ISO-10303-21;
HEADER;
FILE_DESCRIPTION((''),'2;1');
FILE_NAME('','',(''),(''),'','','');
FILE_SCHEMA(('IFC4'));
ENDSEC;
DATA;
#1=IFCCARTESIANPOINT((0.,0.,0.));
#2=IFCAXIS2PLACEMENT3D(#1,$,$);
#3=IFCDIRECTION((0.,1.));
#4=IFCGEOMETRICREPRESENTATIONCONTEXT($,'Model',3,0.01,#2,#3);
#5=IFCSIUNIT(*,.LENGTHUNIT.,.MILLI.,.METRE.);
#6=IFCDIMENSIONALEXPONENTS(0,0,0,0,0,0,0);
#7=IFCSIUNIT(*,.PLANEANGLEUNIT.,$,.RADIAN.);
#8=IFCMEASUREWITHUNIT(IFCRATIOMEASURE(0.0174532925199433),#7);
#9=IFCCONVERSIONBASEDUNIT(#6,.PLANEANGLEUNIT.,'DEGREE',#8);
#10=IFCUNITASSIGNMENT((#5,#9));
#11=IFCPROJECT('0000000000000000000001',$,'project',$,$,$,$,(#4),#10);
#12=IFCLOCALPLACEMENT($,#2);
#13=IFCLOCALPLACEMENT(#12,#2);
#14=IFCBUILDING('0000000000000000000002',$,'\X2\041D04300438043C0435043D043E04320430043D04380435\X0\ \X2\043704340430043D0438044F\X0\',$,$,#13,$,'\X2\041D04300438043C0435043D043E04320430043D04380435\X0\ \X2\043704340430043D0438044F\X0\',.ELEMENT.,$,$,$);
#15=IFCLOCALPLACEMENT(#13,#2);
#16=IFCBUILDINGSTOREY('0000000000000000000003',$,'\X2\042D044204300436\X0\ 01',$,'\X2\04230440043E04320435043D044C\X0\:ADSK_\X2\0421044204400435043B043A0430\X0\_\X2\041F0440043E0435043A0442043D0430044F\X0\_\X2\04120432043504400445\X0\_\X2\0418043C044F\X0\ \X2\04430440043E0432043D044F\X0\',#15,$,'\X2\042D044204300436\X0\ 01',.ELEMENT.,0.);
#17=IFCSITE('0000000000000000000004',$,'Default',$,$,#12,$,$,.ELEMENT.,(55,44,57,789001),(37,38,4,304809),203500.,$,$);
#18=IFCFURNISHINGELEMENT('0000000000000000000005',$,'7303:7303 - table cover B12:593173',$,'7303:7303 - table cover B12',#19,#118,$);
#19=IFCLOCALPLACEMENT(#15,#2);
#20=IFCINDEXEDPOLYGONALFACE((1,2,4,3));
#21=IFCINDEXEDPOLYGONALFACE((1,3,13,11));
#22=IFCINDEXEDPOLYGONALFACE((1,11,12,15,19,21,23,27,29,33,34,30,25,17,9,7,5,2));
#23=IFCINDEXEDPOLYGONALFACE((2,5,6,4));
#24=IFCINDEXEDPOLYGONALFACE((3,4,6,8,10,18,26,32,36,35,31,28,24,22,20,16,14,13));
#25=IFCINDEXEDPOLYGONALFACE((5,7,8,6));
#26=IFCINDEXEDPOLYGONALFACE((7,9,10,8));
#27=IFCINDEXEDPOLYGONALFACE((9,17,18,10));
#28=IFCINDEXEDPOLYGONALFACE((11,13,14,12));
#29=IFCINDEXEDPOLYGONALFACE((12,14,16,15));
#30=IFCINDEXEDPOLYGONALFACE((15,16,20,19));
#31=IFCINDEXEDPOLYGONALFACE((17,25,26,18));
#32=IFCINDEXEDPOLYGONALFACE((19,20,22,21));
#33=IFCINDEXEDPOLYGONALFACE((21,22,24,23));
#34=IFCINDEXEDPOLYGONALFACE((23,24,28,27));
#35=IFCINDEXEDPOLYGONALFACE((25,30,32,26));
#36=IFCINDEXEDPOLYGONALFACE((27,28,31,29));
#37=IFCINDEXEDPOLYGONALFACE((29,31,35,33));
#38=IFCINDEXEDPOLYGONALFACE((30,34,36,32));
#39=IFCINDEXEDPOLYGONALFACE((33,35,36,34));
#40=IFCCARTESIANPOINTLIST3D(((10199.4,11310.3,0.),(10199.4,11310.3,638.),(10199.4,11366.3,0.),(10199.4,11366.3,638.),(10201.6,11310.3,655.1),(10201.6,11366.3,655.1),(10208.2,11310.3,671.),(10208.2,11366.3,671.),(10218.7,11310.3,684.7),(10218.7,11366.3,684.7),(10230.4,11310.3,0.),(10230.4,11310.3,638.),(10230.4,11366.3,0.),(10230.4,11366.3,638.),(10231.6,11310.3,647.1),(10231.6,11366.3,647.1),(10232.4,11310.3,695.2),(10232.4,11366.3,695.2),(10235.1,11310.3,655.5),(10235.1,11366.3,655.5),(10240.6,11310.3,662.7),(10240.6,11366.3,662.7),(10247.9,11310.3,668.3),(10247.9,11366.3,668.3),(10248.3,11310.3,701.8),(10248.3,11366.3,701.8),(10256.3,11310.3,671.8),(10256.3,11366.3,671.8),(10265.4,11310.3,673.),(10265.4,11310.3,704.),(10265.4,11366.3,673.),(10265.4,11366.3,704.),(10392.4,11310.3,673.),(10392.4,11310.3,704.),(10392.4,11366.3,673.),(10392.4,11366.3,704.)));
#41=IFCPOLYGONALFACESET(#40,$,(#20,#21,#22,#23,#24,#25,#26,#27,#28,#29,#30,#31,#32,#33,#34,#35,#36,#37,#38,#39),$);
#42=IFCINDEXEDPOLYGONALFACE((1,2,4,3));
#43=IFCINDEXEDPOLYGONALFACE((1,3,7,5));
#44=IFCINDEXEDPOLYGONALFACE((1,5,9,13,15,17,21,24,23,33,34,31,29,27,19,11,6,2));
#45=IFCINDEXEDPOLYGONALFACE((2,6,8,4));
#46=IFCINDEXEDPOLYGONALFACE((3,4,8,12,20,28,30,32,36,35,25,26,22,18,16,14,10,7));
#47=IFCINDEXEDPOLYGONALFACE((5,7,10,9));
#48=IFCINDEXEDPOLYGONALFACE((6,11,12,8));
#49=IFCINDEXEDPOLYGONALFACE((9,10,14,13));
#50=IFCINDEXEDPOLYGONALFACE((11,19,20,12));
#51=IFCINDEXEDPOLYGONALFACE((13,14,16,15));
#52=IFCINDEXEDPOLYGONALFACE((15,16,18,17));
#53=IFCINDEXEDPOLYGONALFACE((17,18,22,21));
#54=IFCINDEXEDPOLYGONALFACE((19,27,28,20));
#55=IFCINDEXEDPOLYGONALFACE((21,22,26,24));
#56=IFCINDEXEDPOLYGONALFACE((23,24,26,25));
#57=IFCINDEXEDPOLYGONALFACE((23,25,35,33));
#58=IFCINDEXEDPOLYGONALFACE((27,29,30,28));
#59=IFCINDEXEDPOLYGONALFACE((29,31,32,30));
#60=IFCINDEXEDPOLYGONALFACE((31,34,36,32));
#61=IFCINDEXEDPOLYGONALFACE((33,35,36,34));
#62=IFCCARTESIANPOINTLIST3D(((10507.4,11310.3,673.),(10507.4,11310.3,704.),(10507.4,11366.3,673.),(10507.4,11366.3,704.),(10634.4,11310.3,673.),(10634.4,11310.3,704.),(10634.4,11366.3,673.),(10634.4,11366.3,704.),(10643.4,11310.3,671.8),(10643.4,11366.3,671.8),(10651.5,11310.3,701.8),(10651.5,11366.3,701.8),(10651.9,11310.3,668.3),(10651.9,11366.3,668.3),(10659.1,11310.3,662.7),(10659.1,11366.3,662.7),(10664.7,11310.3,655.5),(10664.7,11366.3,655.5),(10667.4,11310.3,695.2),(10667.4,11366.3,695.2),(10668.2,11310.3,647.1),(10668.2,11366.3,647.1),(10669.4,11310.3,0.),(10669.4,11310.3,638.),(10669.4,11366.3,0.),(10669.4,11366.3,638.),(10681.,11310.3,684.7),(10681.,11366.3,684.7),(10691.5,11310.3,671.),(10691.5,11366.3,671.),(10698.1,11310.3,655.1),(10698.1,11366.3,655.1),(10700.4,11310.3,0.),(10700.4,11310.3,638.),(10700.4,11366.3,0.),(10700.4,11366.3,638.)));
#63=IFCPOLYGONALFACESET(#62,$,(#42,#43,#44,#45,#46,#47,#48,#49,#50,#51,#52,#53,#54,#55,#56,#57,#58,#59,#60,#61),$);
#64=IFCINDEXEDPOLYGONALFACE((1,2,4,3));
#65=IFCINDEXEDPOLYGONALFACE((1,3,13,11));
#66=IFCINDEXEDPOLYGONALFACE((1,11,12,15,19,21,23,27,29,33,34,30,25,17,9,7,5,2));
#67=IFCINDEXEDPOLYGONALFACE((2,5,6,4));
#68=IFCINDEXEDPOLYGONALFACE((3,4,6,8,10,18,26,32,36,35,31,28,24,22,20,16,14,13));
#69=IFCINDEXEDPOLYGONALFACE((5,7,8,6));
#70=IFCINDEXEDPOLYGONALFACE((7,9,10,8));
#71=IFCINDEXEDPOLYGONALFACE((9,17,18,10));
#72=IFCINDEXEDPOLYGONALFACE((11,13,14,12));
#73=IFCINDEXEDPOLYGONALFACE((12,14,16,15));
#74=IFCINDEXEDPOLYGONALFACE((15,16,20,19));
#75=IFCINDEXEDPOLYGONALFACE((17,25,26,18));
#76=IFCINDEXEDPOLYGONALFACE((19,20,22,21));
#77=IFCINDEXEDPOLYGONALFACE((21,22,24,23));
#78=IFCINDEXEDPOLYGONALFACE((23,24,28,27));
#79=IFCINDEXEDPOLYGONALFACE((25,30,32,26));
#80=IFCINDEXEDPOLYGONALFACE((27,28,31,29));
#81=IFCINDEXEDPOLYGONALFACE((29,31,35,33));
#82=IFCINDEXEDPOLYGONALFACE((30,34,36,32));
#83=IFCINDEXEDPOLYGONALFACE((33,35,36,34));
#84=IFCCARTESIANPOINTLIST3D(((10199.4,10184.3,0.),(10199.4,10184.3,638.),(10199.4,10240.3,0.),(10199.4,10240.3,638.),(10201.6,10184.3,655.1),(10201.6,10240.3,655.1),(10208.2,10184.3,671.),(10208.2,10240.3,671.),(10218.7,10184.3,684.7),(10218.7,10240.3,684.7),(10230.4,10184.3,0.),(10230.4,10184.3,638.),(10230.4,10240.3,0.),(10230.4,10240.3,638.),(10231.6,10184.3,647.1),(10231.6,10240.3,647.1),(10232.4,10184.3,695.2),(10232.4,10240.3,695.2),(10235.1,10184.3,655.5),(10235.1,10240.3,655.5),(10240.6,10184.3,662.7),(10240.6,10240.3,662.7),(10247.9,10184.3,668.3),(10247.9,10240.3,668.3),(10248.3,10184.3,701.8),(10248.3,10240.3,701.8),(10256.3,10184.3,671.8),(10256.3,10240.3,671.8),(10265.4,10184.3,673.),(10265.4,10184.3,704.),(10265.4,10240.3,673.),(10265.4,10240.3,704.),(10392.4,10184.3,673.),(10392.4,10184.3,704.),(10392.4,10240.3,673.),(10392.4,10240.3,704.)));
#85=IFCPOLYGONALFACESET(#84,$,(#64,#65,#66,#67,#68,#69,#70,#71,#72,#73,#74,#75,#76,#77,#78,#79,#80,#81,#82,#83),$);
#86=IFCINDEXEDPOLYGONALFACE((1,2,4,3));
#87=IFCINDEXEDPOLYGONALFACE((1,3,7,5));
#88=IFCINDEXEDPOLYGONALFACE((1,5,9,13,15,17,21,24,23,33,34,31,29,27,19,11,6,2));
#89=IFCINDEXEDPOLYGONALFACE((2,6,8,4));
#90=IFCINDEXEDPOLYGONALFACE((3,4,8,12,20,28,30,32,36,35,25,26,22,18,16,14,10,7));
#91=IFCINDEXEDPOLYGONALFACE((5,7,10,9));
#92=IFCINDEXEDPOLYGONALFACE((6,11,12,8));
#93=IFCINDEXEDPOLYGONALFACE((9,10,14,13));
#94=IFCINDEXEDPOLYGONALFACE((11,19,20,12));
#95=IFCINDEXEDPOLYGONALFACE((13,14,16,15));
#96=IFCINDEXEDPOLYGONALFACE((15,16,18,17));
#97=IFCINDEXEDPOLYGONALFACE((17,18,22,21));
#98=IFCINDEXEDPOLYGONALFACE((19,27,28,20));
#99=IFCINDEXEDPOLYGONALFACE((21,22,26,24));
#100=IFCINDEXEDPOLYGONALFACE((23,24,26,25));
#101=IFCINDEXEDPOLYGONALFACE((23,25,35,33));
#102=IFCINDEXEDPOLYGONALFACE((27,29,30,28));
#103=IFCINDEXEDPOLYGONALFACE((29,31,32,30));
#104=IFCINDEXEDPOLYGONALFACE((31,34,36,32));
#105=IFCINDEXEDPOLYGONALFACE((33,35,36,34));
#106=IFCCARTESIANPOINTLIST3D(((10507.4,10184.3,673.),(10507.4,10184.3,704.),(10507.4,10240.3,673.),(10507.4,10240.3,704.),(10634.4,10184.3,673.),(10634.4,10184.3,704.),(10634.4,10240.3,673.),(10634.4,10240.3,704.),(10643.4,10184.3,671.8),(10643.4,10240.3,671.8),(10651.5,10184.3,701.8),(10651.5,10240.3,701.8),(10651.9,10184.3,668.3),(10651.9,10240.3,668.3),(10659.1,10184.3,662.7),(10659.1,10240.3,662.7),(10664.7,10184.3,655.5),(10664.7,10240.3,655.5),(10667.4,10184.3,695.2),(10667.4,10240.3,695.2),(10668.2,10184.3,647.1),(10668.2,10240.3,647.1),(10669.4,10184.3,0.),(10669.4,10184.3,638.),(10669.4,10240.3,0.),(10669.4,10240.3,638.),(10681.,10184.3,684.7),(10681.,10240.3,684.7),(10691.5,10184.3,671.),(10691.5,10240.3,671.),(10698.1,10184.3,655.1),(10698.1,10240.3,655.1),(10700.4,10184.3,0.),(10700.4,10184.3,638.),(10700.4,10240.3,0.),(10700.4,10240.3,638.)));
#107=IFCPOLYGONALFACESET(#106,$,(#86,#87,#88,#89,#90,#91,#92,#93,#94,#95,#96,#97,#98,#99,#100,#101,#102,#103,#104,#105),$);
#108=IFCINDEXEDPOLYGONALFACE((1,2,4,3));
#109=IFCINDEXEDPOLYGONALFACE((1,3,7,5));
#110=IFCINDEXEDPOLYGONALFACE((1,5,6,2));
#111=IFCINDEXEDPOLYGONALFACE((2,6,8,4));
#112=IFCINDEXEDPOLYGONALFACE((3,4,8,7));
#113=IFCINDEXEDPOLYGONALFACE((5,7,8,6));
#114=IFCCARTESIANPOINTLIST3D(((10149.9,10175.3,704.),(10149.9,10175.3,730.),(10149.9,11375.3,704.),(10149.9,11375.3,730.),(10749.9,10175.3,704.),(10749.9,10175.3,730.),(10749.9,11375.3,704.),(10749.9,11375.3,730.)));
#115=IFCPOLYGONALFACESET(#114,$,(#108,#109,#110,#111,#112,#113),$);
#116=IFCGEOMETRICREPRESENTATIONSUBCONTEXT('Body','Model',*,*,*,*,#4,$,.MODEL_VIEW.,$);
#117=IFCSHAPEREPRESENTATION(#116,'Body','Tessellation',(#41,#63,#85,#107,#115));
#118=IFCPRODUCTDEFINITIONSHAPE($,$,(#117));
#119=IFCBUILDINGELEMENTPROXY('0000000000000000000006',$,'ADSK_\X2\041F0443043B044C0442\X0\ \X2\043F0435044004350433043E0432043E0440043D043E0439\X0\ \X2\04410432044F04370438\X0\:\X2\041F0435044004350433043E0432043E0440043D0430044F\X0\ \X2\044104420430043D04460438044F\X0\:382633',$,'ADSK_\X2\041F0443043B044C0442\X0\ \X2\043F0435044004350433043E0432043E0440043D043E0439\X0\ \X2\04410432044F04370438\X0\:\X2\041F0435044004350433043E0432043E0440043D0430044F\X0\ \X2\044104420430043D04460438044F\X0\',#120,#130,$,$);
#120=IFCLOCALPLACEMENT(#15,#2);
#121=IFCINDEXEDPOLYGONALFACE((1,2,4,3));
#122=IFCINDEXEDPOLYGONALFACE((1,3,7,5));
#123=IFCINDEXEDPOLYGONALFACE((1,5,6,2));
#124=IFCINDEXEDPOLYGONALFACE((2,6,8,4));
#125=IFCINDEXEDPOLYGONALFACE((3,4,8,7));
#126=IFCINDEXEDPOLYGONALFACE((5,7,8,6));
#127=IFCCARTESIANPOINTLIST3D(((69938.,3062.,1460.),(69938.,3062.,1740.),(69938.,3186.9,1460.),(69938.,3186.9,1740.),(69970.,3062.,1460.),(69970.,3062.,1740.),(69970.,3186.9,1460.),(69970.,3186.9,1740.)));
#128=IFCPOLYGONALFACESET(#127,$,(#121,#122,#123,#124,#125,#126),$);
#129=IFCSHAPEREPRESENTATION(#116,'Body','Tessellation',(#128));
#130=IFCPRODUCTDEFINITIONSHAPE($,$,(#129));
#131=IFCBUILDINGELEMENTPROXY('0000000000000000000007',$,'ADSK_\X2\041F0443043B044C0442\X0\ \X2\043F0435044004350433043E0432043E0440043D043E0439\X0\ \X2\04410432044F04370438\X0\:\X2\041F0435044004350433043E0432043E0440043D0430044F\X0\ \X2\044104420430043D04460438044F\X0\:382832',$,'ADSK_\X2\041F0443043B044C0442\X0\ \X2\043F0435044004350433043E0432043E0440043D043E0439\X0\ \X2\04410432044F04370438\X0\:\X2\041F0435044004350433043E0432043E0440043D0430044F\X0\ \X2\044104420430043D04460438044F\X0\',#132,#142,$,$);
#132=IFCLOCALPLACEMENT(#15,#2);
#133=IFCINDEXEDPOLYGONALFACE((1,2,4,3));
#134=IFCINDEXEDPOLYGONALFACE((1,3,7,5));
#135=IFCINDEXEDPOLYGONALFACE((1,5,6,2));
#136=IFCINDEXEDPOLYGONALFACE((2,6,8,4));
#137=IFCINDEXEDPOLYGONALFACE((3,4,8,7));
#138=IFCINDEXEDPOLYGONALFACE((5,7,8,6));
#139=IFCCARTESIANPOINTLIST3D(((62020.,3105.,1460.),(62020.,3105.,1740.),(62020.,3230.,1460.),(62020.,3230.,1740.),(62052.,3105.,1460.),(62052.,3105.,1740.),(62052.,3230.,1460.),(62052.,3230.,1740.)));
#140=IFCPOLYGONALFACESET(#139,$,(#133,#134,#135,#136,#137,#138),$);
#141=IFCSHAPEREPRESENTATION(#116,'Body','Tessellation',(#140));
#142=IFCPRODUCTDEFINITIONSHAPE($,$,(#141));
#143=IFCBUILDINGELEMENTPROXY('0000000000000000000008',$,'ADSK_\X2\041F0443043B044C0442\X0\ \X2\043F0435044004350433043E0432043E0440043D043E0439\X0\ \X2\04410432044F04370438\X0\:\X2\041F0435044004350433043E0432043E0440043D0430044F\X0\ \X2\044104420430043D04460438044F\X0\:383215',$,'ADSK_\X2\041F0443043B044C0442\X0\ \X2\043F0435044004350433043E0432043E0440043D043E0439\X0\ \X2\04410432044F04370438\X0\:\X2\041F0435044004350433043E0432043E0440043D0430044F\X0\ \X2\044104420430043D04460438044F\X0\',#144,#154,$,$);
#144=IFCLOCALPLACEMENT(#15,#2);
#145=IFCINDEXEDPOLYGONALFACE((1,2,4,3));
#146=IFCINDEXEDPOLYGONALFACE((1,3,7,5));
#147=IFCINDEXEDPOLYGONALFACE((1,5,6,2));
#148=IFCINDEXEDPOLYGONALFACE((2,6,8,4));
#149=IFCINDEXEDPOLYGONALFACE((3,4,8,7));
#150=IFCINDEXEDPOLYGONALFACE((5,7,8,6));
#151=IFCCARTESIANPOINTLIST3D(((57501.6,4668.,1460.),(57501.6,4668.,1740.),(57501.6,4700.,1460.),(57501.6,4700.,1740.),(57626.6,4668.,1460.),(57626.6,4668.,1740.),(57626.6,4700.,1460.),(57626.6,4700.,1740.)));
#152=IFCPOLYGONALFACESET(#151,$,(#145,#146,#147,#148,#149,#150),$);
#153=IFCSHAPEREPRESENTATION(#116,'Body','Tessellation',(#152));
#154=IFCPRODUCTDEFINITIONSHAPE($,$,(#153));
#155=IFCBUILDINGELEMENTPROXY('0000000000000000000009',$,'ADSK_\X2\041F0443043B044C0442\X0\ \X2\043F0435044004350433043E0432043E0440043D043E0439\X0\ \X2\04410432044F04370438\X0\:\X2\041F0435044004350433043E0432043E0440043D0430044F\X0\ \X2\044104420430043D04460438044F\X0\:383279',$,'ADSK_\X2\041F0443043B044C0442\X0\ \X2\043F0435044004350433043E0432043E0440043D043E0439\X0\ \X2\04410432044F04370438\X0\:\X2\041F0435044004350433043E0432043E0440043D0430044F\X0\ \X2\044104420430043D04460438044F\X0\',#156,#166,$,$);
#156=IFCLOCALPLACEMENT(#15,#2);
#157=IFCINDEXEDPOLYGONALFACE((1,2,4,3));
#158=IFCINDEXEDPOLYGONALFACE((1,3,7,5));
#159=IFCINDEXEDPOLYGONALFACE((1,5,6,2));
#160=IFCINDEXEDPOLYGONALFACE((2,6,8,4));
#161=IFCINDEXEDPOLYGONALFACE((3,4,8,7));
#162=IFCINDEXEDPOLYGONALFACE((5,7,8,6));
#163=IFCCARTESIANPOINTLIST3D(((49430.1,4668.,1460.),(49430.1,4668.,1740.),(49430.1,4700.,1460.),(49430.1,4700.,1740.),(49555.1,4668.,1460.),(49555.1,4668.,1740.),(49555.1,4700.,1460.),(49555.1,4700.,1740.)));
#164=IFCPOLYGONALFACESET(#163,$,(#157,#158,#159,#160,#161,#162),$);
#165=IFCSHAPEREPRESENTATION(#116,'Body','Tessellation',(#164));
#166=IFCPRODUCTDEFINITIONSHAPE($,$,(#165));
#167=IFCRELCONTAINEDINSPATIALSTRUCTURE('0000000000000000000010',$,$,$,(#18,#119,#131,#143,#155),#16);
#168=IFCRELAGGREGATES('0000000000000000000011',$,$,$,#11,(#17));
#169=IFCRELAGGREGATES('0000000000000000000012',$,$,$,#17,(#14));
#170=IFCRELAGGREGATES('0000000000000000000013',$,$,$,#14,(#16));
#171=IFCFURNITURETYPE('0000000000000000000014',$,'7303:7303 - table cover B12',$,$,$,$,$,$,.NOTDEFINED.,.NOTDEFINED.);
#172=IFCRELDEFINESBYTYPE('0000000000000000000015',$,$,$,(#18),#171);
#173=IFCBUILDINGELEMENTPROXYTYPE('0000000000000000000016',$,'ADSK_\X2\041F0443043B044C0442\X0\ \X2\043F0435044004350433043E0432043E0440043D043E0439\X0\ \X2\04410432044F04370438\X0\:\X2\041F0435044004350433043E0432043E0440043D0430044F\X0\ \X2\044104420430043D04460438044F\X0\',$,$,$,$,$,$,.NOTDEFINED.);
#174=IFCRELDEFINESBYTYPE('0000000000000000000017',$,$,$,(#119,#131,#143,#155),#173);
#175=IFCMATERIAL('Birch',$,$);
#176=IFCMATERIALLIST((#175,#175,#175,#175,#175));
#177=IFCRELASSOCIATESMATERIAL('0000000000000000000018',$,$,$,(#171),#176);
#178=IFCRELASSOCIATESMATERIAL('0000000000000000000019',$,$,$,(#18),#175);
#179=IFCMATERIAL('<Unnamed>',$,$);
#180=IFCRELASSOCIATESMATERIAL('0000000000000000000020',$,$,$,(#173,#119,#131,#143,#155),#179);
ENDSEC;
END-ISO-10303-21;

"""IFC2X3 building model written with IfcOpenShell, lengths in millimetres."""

from ifc_helpers import new_model, entity, si_unit, converted_unit, direction, frame, frame_2d, origin, origin_2d_with_axis, place, context, subcontext, project, spatial, polyline, circle_curve, parameter, trimmed, segment, composite_curve, rectangle, outline, extrude, source, transform, mapped, material, material_list, type_object, type_shapes, element, save


model = new_model("IFC2X3")

# Units and contexts
model_context = context("Model", 3, precision=0.01, world=origin(), true_north=direction((0.0, 1.0)))
body_context = subcontext(model_context, "Body", "Model", "MODEL_VIEW")
ifc_project = project(units=[si_unit("LENGTHUNIT", "METRE", prefix="MILLI"), converted_unit("PLANEANGLEUNIT", "DEGREE", entity("IfcRatioMeasure", 0.0174532925199433), si_unit("PLANEANGLEUNIT", "RADIAN"), dimensions=[0, 0, 0, 0, 0, 0, 0])], contexts=[model_context])

# Site, building, storey
site_placement = place(None, origin())
site = spatial("IfcSite", under=ifc_project, at=site_placement, Name="Default", CompositionType="ELEMENT", RefLatitude=(55, 44, 57, 789001), RefLongitude=(37, 38, 4, 304809), RefElevation=203500.0)
building_placement = place(site_placement, origin())
building = spatial("IfcBuilding", under=site, at=building_placement, Name="Наименование здания", LongName="Наименование здания", CompositionType="ELEMENT")
storey_placement = place(building_placement, origin())
storey = spatial("IfcBuildingStorey", under=building, at=storey_placement, Name="Этаж 01", ObjectType="Уровень:ADSK_Стрелка_Проектная_Вверх_Имя уровня", LongName="Этаж 01", CompositionType="ELEMENT", Elevation=0.0)

# Furnishing element
ifc_material_1 = material(Name="Birch")
ifc_material_list_1 = material_list([ifc_material_1, ifc_material_1, ifc_material_1, ifc_material_1, ifc_material_1])
furniture_type = type_object("IfcFurnitureType", Name="7303:7303 - table cover B12", material=ifc_material_list_1)
shared_shape_1 = source(origin(), body_context, "Body", "SweptSolid", [
    extrude(outline(composite_curve([segment(polyline([(-200.2, -120.5), (-169.2, -120.5)]), True, "CONTINUOUS"), segment(polyline([(-169.2, -120.5), (-169.2, 6.5)]), True, "CONTINUOUS"), segment(trimmed(circle_curve(frame_2d((-134.2, 6.5), x_axis=(0.0, -1.0)), 35.0), [parameter(180.0)], [parameter(270.0)], True, "PARAMETER"), False, "CONTINUOUS"), segment(polyline([(-134.2, 41.5), (503.8, 41.5)]), True, "CONTINUOUS"), segment(polyline([(503.8, 41.5), (503.8, 72.5)]), True, "CONTINUOUS"), segment(polyline([(503.8, 72.5), (-134.2, 72.5)]), True, "CONTINUOUS"), segment(trimmed(circle_curve(frame_2d((-134.2, 6.5), x_axis=(0.0, -1.0)), 66.0), [parameter(180.0)], [parameter(270.0)], True, "PARAMETER"), True, "CONTINUOUS"), segment(polyline([(-200.2, 6.5), (-200.2, -120.5)]), True, "CONTINUOUS")], self_intersect=False)), frame((535.0, 178.0, 503.8), z_axis=(1.0, 0.0, 0.0), x_axis=(0.0, 0.0, -1.0)), (0.0, 0.0, 1.0), 56.0),
    extrude(outline(composite_curve([segment(polyline([(-120.5, -200.2), (6.5, -200.2)]), True, "CONTINUOUS"), segment(trimmed(circle_curve(frame_2d((6.5, -134.2), x_axis=(-1.0, 0.0)), 66.0), [parameter(90.0)], [parameter(180.0)], True, "PARAMETER"), True, "CONTINUOUS"), segment(polyline([(72.5, -134.2), (72.5, 503.8)]), True, "CONTINUOUS"), segment(polyline([(72.5, 503.8), (41.5, 503.8)]), True, "CONTINUOUS"), segment(polyline([(41.5, 503.8), (41.5, -134.2)]), True, "CONTINUOUS"), segment(trimmed(circle_curve(frame_2d((6.5, -134.2), x_axis=(-1.0, 0.0)), 35.0), [parameter(90.0)], [parameter(180.0)], True, "PARAMETER"), False, "CONTINUOUS"), segment(polyline([(6.5, -169.2), (-120.5, -169.2)]), True, "CONTINUOUS"), segment(polyline([(-120.5, -169.2), (-120.5, -200.2)]), True, "CONTINUOUS")], self_intersect=False)), frame((535.0, -178.0, 503.8), z_axis=(1.0, 0.0, 0.0), x_axis=(0.0, -1.0, 0.0)), (0.0, 0.0, 1.0), 56.0),
    extrude(outline(composite_curve([segment(polyline([(-200.2, -120.5), (-169.2, -120.5)]), True, "CONTINUOUS"), segment(polyline([(-169.2, -120.5), (-169.2, 6.5)]), True, "CONTINUOUS"), segment(trimmed(circle_curve(frame_2d((-134.2, 6.5), x_axis=(0.0, -1.0)), 35.0), [parameter(180.0)], [parameter(270.0)], True, "PARAMETER"), False, "CONTINUOUS"), segment(polyline([(-134.2, 41.5), (503.8, 41.5)]), True, "CONTINUOUS"), segment(polyline([(503.8, 41.5), (503.8, 72.5)]), True, "CONTINUOUS"), segment(polyline([(503.8, 72.5), (-134.2, 72.5)]), True, "CONTINUOUS"), segment(trimmed(circle_curve(frame_2d((-134.2, 6.5), x_axis=(0.0, -1.0)), 66.0), [parameter(180.0)], [parameter(270.0)], True, "PARAMETER"), True, "CONTINUOUS"), segment(polyline([(-200.2, 6.5), (-200.2, -120.5)]), True, "CONTINUOUS")], self_intersect=False)), frame((-591.0, 178.0, 503.8), z_axis=(1.0, 0.0, 0.0), x_axis=(0.0, 0.0, -1.0)), (0.0, 0.0, 1.0), 56.0),
    extrude(outline(composite_curve([segment(polyline([(-120.5, -200.2), (6.5, -200.2)]), True, "CONTINUOUS"), segment(trimmed(circle_curve(frame_2d((6.5, -134.2), x_axis=(-1.0, 0.0)), 66.0), [parameter(90.0)], [parameter(180.0)], True, "PARAMETER"), True, "CONTINUOUS"), segment(polyline([(72.5, -134.2), (72.5, 503.8)]), True, "CONTINUOUS"), segment(polyline([(72.5, 503.8), (41.5, 503.8)]), True, "CONTINUOUS"), segment(polyline([(41.5, 503.8), (41.5, -134.2)]), True, "CONTINUOUS"), segment(trimmed(circle_curve(frame_2d((6.5, -134.2), x_axis=(-1.0, 0.0)), 35.0), [parameter(90.0)], [parameter(180.0)], True, "PARAMETER"), False, "CONTINUOUS"), segment(polyline([(6.5, -169.2), (-120.5, -169.2)]), True, "CONTINUOUS"), segment(polyline([(-120.5, -169.2), (-120.5, -200.2)]), True, "CONTINUOUS")], self_intersect=False)), frame((-591.0, -178.0, 503.8), z_axis=(1.0, 0.0, 0.0), x_axis=(0.0, -1.0, 0.0)), (0.0, 0.0, 1.0), 56.0),
    extrude(rectangle(XDim=1200.0, YDim=600.0, at=origin_2d_with_axis()), frame((0.0, 0.0, 704.0), z_axis=(0.0, 0.0, 1.0), x_axis=(-1.0, 0.0, 0.0)), (0.0, 0.0, 1.0), 26.0),
])
type_shapes(furniture_type, [shared_shape_1])
for number, where, z_axis, x_axis, name in (
    (1, (10449.9, 10775.3, 0.0), (0.0, 0.0, 1.0), (0.0, 1.0, 0.0), "7303:7303 - table cover B12:593173"),
):
    element("IfcFurnishingElement", number, at=place(storey_placement, frame(where, z_axis=z_axis, x_axis=x_axis)), inside=storey, type_object=furniture_type, material=ifc_material_1, Name=name, ObjectType="7303:7303 - table cover B12", context=body_context, shape_type="MappedRepresentation", body=[
        mapped(shared_shape_1, transform((0.0, 0.0, 0.0), scale=1.0)),
    ])

# Building element proxies
ifc_material_2 = material(Name="<Unnamed>")
building_element_proxy_type_1 = type_object("IfcBuildingElementProxyType", Name="ADSK_Пульт переговорной связи:Переговорная станция", PredefinedType="NOTDEFINED", material=ifc_material_2)
shared_shape_2 = source(origin(), body_context, "Body", "SweptSolid", [
    extrude(rectangle(XDim=125.0, YDim=32.0, at=origin_2d_with_axis()), frame((0.0, 16.0, -140.0), z_axis=(0.0, 0.0, 1.0), x_axis=(-1.0, 0.0, 0.0)), (0.0, 0.0, 1.0), 280.0),
])
type_shapes(building_element_proxy_type_1, [shared_shape_2])
for number, where, z_axis, x_axis, name in (
    (2, (69938.0, 3124.4, 1600.0), (0.0, 0.0, 1.0), (0.0, -1.0, 0.0), "ADSK_Пульт переговорной связи:Переговорная станция:382633"),
    (3, (62052.0, 3167.5, 1600.0), (0.0, 0.0, 1.0), (0.0, 1.0, 0.0), "ADSK_Пульт переговорной связи:Переговорная станция:382832"),
):
    element("IfcBuildingElementProxy", number, at=place(storey_placement, frame(where, z_axis=z_axis, x_axis=x_axis)), inside=storey, type_object=building_element_proxy_type_1, material=ifc_material_2, Name=name, ObjectType="ADSK_Пульт переговорной связи:Переговорная станция", context=body_context, shape_type="MappedRepresentation", body=[
        mapped(shared_shape_2, transform((0.0, 0.0, 0.0), scale=1.0)),
    ])
for number, where, name in (
    (4, (57564.1, 4668.0, 1600.0), "ADSK_Пульт переговорной связи:Переговорная станция:383215"),
    (5, (49492.6, 4668.0, 1600.0), "ADSK_Пульт переговорной связи:Переговорная станция:383279"),
):
    element("IfcBuildingElementProxy", number, at=place(storey_placement, frame(where)), inside=storey, type_object=building_element_proxy_type_1, material=ifc_material_2, Name=name, ObjectType="ADSK_Пульт переговорной связи:Переговорная станция", context=body_context, shape_type="MappedRepresentation", body=[
        mapped(shared_shape_2, transform((0.0, 0.0, 0.0), scale=1.0)),
    ])

save(model, "model.ifc")
